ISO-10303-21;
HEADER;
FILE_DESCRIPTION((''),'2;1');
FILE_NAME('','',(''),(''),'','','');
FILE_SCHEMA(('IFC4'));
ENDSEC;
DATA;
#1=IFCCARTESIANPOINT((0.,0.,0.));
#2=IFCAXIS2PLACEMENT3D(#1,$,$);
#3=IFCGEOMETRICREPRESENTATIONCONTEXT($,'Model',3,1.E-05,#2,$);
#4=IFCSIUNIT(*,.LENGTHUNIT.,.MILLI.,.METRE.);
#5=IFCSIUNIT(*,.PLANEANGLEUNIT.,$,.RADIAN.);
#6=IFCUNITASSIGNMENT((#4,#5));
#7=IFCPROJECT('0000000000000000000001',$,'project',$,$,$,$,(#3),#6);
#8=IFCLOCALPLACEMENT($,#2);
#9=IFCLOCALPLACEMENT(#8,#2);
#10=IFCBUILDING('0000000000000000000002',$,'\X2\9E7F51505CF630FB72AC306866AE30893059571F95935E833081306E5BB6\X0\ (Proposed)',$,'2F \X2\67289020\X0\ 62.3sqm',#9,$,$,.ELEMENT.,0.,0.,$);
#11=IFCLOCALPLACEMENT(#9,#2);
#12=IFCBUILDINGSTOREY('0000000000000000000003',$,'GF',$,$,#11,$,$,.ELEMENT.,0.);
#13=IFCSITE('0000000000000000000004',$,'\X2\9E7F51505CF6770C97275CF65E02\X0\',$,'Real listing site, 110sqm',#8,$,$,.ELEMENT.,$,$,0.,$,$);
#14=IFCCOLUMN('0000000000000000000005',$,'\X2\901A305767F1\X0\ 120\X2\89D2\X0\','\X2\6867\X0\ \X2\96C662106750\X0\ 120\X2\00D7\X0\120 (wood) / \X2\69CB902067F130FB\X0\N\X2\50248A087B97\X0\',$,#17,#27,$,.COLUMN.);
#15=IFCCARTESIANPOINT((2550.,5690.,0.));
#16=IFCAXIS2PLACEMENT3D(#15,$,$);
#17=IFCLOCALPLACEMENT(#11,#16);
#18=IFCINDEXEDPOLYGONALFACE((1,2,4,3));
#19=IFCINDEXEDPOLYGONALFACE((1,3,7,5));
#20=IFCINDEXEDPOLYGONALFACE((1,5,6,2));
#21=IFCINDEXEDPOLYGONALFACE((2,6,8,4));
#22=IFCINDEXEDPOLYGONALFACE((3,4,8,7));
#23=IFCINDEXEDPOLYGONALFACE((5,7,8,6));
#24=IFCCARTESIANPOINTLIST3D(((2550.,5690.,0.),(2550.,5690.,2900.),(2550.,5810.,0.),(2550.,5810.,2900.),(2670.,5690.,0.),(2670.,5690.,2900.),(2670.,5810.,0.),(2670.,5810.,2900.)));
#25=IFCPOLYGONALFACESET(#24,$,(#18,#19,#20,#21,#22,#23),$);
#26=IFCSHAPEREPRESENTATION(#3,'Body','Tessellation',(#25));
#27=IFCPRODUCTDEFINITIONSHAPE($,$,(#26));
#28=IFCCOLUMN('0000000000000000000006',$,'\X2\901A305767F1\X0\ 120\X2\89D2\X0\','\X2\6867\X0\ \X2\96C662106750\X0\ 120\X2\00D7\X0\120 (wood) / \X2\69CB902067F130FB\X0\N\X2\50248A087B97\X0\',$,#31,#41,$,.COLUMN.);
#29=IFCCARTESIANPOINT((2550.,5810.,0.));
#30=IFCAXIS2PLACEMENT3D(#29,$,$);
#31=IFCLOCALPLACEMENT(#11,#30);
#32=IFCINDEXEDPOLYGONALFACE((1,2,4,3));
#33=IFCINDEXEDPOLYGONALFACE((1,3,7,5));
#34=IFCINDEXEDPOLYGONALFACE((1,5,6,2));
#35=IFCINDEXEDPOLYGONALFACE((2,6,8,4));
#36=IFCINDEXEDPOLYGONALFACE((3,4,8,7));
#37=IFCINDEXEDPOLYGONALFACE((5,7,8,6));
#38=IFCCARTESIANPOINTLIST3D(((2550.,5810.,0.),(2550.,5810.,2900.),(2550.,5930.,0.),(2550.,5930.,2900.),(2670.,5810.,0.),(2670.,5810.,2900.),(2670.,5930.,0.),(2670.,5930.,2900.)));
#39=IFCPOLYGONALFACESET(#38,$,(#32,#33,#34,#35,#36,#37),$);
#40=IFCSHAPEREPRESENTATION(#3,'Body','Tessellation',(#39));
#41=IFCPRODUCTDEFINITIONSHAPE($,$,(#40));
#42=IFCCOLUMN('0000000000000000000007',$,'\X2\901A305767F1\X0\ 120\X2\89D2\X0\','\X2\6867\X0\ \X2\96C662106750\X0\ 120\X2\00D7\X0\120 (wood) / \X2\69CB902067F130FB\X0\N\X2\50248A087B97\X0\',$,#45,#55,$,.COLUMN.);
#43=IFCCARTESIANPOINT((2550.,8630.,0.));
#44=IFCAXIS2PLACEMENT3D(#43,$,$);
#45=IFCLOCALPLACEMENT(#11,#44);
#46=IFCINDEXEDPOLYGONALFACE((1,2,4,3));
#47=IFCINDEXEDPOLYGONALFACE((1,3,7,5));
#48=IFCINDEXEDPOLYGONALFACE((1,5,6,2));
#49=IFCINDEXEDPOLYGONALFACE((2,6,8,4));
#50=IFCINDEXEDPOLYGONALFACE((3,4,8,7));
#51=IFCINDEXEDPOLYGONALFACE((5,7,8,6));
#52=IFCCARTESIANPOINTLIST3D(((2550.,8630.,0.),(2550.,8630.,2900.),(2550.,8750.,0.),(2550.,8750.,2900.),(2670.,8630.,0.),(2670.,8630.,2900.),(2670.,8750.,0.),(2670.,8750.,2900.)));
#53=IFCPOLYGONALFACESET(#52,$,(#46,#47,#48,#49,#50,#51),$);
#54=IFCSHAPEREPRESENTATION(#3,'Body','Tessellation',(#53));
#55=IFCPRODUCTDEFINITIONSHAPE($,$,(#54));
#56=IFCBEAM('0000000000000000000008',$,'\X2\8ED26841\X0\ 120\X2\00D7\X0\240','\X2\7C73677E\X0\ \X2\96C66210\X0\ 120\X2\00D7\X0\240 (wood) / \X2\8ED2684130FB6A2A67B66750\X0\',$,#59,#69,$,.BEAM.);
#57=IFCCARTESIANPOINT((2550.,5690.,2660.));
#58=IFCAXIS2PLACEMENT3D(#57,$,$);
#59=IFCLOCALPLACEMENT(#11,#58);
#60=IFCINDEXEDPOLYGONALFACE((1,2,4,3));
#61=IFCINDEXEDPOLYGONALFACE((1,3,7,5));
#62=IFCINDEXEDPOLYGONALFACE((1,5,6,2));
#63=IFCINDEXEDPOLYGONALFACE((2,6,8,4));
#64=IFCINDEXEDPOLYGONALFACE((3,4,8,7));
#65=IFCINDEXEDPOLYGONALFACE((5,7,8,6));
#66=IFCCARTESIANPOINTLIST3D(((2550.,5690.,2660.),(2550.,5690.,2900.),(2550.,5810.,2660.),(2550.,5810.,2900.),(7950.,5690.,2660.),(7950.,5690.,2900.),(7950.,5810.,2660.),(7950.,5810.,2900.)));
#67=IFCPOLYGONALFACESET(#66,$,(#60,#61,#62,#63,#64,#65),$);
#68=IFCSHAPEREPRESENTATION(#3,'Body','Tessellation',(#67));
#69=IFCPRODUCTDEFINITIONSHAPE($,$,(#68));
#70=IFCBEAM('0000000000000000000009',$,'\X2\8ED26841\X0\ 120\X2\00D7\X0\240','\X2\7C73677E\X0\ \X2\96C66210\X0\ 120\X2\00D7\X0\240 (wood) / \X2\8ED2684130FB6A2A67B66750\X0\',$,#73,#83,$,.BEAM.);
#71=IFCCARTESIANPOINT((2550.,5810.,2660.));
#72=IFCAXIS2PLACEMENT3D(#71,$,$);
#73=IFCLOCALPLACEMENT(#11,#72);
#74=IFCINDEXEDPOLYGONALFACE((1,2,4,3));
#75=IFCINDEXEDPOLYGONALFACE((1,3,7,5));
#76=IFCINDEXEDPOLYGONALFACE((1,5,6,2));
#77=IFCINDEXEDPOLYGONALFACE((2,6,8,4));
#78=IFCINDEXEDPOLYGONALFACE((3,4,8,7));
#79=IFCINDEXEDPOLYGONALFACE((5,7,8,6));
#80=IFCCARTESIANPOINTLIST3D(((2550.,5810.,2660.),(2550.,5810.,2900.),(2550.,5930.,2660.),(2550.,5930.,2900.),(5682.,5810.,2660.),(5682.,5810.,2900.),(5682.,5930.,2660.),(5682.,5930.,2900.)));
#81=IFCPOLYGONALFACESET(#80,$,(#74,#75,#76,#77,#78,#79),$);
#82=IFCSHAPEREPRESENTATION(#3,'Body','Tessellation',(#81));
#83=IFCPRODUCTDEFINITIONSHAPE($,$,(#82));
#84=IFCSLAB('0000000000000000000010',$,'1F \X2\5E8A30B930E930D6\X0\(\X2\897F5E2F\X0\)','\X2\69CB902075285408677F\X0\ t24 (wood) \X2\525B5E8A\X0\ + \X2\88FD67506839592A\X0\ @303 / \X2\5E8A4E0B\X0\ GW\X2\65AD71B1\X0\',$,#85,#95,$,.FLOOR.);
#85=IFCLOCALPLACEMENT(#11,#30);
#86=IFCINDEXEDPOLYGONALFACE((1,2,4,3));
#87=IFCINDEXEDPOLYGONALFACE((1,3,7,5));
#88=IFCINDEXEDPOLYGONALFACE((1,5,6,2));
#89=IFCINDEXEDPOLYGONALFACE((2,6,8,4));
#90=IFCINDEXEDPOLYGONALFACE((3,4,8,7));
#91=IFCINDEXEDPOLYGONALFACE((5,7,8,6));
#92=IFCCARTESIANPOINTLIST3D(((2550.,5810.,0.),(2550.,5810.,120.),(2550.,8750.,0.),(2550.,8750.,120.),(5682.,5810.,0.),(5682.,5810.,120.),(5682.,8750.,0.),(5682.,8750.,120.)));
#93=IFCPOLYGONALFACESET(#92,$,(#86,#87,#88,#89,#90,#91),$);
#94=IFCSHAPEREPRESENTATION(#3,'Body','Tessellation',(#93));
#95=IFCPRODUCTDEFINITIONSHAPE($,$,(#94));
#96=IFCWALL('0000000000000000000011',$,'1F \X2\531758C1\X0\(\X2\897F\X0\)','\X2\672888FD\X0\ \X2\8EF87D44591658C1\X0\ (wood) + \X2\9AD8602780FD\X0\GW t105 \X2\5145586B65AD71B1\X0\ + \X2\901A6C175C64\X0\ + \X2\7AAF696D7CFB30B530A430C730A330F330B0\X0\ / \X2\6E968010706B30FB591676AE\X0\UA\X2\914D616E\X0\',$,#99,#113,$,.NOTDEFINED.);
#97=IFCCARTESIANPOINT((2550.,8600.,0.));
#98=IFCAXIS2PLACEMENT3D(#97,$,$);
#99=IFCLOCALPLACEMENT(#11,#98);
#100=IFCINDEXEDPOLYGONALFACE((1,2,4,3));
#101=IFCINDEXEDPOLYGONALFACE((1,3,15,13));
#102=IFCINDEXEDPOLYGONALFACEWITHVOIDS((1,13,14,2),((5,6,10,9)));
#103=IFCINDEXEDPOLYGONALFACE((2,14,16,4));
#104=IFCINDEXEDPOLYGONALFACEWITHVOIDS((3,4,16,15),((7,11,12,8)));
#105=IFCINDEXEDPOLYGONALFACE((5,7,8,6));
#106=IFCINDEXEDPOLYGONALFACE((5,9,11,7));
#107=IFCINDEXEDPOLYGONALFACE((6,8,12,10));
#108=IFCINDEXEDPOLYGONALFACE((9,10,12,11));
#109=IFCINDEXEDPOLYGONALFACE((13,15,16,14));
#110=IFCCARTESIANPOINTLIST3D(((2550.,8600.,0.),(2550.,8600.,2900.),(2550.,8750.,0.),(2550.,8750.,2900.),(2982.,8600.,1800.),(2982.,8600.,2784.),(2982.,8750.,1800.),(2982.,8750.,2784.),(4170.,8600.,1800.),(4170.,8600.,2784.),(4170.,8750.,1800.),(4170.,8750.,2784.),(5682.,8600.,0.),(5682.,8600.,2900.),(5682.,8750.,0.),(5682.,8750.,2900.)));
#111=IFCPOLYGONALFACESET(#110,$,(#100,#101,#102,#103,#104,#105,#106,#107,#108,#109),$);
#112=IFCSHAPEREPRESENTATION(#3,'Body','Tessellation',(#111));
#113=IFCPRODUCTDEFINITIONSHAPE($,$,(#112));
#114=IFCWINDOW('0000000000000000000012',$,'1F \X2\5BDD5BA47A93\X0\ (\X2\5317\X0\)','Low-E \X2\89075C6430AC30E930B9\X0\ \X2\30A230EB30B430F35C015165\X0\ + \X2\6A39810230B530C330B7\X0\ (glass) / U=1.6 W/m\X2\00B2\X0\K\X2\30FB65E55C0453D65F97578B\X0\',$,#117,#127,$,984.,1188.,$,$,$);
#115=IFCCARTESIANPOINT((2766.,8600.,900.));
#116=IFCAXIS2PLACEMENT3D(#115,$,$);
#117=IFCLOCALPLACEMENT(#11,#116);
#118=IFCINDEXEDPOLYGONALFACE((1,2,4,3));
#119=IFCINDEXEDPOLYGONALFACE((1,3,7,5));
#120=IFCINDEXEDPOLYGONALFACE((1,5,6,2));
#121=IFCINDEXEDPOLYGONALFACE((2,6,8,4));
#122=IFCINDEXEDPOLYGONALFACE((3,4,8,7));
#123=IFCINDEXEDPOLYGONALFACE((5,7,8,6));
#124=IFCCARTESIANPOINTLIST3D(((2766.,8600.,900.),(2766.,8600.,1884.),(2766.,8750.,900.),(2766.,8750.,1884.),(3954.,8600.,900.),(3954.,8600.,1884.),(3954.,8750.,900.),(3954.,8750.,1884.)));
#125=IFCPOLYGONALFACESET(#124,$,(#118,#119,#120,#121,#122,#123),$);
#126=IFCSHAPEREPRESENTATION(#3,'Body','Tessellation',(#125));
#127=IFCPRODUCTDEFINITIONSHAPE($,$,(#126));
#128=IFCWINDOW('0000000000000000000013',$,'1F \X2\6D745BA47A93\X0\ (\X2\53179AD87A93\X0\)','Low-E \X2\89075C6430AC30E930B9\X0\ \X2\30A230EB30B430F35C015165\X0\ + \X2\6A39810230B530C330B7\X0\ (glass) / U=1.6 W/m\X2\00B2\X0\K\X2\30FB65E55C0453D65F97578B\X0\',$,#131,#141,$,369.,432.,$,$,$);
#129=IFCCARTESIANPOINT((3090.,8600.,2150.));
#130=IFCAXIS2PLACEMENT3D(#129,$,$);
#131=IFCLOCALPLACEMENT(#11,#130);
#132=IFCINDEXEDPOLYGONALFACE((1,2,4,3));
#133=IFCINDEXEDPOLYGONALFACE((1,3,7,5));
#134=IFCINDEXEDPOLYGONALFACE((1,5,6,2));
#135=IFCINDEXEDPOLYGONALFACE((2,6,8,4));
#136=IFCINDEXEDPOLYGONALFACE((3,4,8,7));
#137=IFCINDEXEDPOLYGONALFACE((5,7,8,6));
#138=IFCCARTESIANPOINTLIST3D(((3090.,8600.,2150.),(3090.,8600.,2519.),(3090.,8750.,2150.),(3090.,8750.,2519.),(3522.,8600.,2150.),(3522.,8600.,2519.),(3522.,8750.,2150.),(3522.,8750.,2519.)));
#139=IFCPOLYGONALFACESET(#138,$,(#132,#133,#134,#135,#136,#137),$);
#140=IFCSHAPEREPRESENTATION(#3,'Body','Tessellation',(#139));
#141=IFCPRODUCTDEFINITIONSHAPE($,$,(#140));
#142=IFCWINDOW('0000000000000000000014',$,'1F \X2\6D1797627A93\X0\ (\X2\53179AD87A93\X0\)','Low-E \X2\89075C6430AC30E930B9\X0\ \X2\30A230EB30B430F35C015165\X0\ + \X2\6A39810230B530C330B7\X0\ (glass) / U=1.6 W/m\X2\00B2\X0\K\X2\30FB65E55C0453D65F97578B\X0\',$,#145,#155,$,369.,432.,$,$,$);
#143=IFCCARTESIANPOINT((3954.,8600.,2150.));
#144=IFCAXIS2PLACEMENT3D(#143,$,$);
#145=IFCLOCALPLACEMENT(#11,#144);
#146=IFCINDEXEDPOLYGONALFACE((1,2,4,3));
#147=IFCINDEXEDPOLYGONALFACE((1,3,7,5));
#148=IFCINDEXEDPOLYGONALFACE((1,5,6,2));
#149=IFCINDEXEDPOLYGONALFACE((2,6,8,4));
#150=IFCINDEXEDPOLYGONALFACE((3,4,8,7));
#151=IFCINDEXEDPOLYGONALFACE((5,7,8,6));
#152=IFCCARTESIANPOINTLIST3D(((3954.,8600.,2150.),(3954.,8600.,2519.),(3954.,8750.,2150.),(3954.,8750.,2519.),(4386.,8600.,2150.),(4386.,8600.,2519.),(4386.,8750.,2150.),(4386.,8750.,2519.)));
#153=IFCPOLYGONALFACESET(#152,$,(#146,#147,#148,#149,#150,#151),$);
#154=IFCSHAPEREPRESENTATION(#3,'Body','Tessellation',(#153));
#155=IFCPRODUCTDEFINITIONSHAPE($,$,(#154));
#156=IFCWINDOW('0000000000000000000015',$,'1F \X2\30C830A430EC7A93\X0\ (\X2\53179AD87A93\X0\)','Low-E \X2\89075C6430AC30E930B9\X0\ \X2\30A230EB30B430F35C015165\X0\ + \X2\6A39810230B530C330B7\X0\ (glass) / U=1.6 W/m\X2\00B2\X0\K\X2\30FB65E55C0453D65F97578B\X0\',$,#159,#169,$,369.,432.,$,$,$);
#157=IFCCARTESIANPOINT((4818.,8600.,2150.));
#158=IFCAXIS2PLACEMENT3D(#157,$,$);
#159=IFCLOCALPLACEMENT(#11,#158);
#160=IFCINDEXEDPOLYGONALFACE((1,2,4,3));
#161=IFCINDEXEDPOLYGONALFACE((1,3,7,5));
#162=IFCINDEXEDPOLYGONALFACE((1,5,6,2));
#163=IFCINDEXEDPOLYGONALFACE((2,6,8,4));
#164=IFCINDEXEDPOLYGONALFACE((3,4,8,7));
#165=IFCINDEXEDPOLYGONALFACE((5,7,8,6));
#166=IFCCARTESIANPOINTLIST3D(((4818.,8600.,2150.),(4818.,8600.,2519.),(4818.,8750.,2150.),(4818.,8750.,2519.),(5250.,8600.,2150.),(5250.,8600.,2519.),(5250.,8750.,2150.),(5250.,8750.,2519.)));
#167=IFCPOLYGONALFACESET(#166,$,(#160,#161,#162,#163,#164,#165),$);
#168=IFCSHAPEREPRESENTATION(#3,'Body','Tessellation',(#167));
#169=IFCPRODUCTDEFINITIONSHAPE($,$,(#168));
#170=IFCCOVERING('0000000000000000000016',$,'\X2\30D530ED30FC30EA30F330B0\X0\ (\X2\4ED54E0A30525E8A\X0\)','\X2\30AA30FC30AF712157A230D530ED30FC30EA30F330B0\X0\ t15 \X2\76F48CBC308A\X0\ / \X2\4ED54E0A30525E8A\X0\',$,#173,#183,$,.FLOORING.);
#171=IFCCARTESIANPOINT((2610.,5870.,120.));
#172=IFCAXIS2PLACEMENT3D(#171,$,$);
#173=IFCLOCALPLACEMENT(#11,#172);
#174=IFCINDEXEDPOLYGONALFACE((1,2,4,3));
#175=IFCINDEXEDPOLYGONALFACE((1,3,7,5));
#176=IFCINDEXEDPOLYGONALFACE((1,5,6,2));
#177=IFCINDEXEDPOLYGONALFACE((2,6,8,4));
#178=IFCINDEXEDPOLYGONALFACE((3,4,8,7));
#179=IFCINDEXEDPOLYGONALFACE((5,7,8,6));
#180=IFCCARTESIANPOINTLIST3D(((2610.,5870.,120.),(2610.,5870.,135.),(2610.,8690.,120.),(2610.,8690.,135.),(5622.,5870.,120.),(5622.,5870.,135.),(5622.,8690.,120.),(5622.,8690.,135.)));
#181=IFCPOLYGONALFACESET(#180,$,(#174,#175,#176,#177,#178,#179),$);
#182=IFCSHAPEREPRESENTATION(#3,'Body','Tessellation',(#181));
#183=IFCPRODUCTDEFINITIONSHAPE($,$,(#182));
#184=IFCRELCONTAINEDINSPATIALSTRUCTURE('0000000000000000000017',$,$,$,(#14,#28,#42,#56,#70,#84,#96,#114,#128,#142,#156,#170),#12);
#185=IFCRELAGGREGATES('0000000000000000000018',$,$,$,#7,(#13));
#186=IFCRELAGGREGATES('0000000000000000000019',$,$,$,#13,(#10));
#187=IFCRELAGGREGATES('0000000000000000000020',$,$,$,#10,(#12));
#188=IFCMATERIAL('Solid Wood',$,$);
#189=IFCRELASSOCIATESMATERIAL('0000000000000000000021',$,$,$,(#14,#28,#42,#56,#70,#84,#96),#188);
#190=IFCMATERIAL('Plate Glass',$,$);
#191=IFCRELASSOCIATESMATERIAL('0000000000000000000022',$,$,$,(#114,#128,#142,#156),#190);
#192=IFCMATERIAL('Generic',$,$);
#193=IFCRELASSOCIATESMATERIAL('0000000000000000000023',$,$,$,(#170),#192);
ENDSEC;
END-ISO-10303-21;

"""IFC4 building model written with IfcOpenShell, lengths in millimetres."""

from ifc_helpers import new_model, si_unit, frame, frame_2d, origin, place, context, project, spatial, rectangle, extrude, material, element, fill, save


model = new_model("IFC4")

# Units and contexts
model_context = context("Model", 3, precision=1e-05, world=origin())
ifc_project = project(units=[si_unit("LENGTHUNIT", "METRE", prefix="MILLI"), si_unit("PLANEANGLEUNIT", "RADIAN")], contexts=[model_context])

# Site, building, storey
site_placement = place(None, origin())
site = spatial("IfcSite", under=ifc_project, at=site_placement, Name="鹿児島県霧島市", ObjectType="Real listing site, 110sqm", CompositionType="ELEMENT", RefElevation=0.0)
building_placement = place(site_placement, origin())
building = spatial("IfcBuilding", under=site, at=building_placement, Name="鹿児島・犬と暮らす土間広めの家 (Proposed)", ObjectType="2F 木造 62.3sqm", CompositionType="ELEMENT", ElevationOfRefHeight=0.0, ElevationOfTerrain=0.0)
storey_placement = place(building_placement, origin())
storey = spatial("IfcBuildingStorey", under=building, at=storey_placement, Name="GF", CompositionType="ELEMENT", Elevation=0.0)

# Columns
ifc_material_1 = material(Name="Solid Wood")
column_1_placement = place(storey_placement, frame((2550.0, 5690.0, 0.0)))
element("IfcColumn", 1, at=column_1_placement, inside=storey, material=ifc_material_1, Name="通し柱 120角", Description="桧 集成材 120×120 (wood) / 構造柱・N値計算", PredefinedType="COLUMN", context=model_context, shape_type="SweptSolid", body=[
    extrude(rectangle(XDim=120.0, YDim=120.0, at=frame_2d((60.0, 60.0))), frame((2550.0, 5690.0, 0.0)), (0.0, 0.0, 1.0), 2900.0),
])
column_2_placement = place(storey_placement, frame((2550.0, 5810.0, 0.0)))
element("IfcColumn", 2, at=column_2_placement, inside=storey, material=ifc_material_1, Name="通し柱 120角", Description="桧 集成材 120×120 (wood) / 構造柱・N値計算", PredefinedType="COLUMN", context=model_context, shape_type="SweptSolid", body=[
    extrude(rectangle(XDim=120.0, YDim=120.0, at=frame_2d((60.0, 60.0))), frame((2550.0, 5810.0, 0.0)), (0.0, 0.0, 1.0), 2900.0),
])
column_3_placement = place(storey_placement, frame((2550.0, 8630.0, 0.0)))
element("IfcColumn", 3, at=column_3_placement, inside=storey, material=ifc_material_1, Name="通し柱 120角", Description="桧 集成材 120×120 (wood) / 構造柱・N値計算", PredefinedType="COLUMN", context=model_context, shape_type="SweptSolid", body=[
    extrude(rectangle(XDim=120.0, YDim=120.0, at=frame_2d((60.0, 60.0))), frame((2550.0, 8630.0, 0.0)), (0.0, 0.0, 1.0), 2900.0),
])

# Beams
beam_1_placement = place(storey_placement, frame((2550.0, 5690.0, 2660.0)))
element("IfcBeam", 4, at=beam_1_placement, inside=storey, material=ifc_material_1, Name="軒桁 120×240", Description="米松 集成 120×240 (wood) / 軒桁・横架材", PredefinedType="BEAM", context=model_context, shape_type="SweptSolid", body=[
    extrude(rectangle(XDim=5400.0, YDim=120.0, at=frame_2d((2700.0, 60.0))), frame((2550.0, 5690.0, 2660.0)), (0.0, 0.0, 1.0), 240.0),
])
beam_2_placement = place(storey_placement, frame((2550.0, 5810.0, 2660.0)))
element("IfcBeam", 5, at=beam_2_placement, inside=storey, material=ifc_material_1, Name="軒桁 120×240", Description="米松 集成 120×240 (wood) / 軒桁・横架材", PredefinedType="BEAM", context=model_context, shape_type="SweptSolid", body=[
    extrude(rectangle(XDim=3132.0, YDim=120.0, at=frame_2d((1566.0, 60.0))), frame((2550.0, 5810.0, 2660.0)), (0.0, 0.0, 1.0), 240.0),
])

# Slab
slab_placement = place(storey_placement, frame((2550.0, 5810.0, 0.0)))
element("IfcSlab", 6, at=slab_placement, inside=storey, material=ifc_material_1, Name="1F 床スラブ(西帯)", Description="構造用合板 t24 (wood) 剛床 + 製材根太 @303 / 床下 GW断熱", PredefinedType="FLOOR", context=model_context, shape_type="SweptSolid", body=[
    extrude(rectangle(XDim=3132.0, YDim=2940.0, at=frame_2d((1566.0, 1470.0))), frame((2550.0, 5810.0, 0.0)), (0.0, 0.0, 1.0), 120.0),
])

# Wall, openings, windows
wall_1_placement = place(storey_placement, frame((2550.0, 8600.0, 0.0)))
wall_1 = element("IfcWall", 7, at=wall_1_placement, inside=storey, material=ifc_material_1, Name="1F 北壁(西)", Description="木製 軸組外壁 (wood) + 高性能GW t105 充填断熱 + 通気層 + 窯業系サイディング / 準耐火・外皮UA配慮", PredefinedType="NOTDEFINED", context=model_context, shape_type="SweptSolid", body=[
    extrude(rectangle(XDim=3132.0, YDim=150.0, at=frame_2d((1566.0, 75.0))), frame((2550.0, 8600.0, 0.0)), (0.0, 0.0, 1.0), 2900.0),
])
opening_1_placement = place(storey_placement, frame((2766.0, 8600.0, 900.0)))
opening_1 = element("IfcOpeningElement", 8, at=opening_1_placement, cuts=wall_1, PredefinedType="NOTDEFINED", context=model_context, shape_type="SweptSolid", body=[
    extrude(rectangle(XDim=1188.0, YDim=150.0, at=frame_2d((594.0, 75.0))), frame((2766.0, 8600.0, 900.0)), (0.0, 0.0, 1.0), 984.0),
])
opening_2_placement = place(storey_placement, frame((3090.0, 8600.0, 2150.0)))
opening_2 = element("IfcOpeningElement", 9, at=opening_2_placement, cuts=wall_1, PredefinedType="NOTDEFINED", context=model_context, shape_type="SweptSolid", body=[
    extrude(rectangle(XDim=432.0, YDim=150.0, at=frame_2d((216.0, 75.0))), frame((3090.0, 8600.0, 2150.0)), (0.0, 0.0, 1.0), 369.0),
])
opening_3_placement = place(storey_placement, frame((3954.0, 8600.0, 2150.0)))
opening_3 = element("IfcOpeningElement", 10, at=opening_3_placement, cuts=wall_1, PredefinedType="NOTDEFINED", context=model_context, shape_type="SweptSolid", body=[
    extrude(rectangle(XDim=432.0, YDim=150.0, at=frame_2d((216.0, 75.0))), frame((3954.0, 8600.0, 2150.0)), (0.0, 0.0, 1.0), 369.0),
])
opening_4_placement = place(storey_placement, frame((4818.0, 8600.0, 2150.0)))
opening_4 = element("IfcOpeningElement", 11, at=opening_4_placement, cuts=wall_1, PredefinedType="NOTDEFINED", context=model_context, shape_type="SweptSolid", body=[
    extrude(rectangle(XDim=432.0, YDim=150.0, at=frame_2d((216.0, 75.0))), frame((4818.0, 8600.0, 2150.0)), (0.0, 0.0, 1.0), 369.0),
])
ifc_material_2 = material(Name="Plate Glass")
window_1_placement = place(storey_placement, frame((2766.0, 8600.0, 900.0)))
window_1 = element("IfcWindow", 12, at=window_1_placement, inside=storey, material=ifc_material_2, Name="1F 寝室窓 (北)", Description="Low-E 複層ガラス アルゴン封入 + 樹脂サッシ (glass) / U=1.6 W/m²K・日射取得型", OverallHeight=984.0, OverallWidth=1188.0, context=model_context, shape_type="SweptSolid", body=[
    extrude(rectangle(XDim=1188.0, YDim=150.0, at=frame_2d((594.0, 75.0))), frame((2766.0, 8600.0, 900.0)), (0.0, 0.0, 1.0), 984.0),
])
fill(opening_1, window_1)
window_2_placement = place(storey_placement, frame((3090.0, 8600.0, 2150.0)))
window_2 = element("IfcWindow", 13, at=window_2_placement, inside=storey, material=ifc_material_2, Name="1F 浴室窓 (北高窓)", Description="Low-E 複層ガラス アルゴン封入 + 樹脂サッシ (glass) / U=1.6 W/m²K・日射取得型", OverallHeight=369.0, OverallWidth=432.0, context=model_context, shape_type="SweptSolid", body=[
    extrude(rectangle(XDim=432.0, YDim=150.0, at=frame_2d((216.0, 75.0))), frame((3090.0, 8600.0, 2150.0)), (0.0, 0.0, 1.0), 369.0),
])
fill(opening_2, window_2)
window_3_placement = place(storey_placement, frame((3954.0, 8600.0, 2150.0)))
window_3 = element("IfcWindow", 14, at=window_3_placement, inside=storey, material=ifc_material_2, Name="1F 洗面窓 (北高窓)", Description="Low-E 複層ガラス アルゴン封入 + 樹脂サッシ (glass) / U=1.6 W/m²K・日射取得型", OverallHeight=369.0, OverallWidth=432.0, context=model_context, shape_type="SweptSolid", body=[
    extrude(rectangle(XDim=432.0, YDim=150.0, at=frame_2d((216.0, 75.0))), frame((3954.0, 8600.0, 2150.0)), (0.0, 0.0, 1.0), 369.0),
])
fill(opening_3, window_3)
window_4_placement = place(storey_placement, frame((4818.0, 8600.0, 2150.0)))
window_4 = element("IfcWindow", 15, at=window_4_placement, inside=storey, material=ifc_material_2, Name="1F トイレ窓 (北高窓)", Description="Low-E 複層ガラス アルゴン封入 + 樹脂サッシ (glass) / U=1.6 W/m²K・日射取得型", OverallHeight=369.0, OverallWidth=432.0, context=model_context, shape_type="SweptSolid", body=[
    extrude(rectangle(XDim=432.0, YDim=150.0, at=frame_2d((216.0, 75.0))), frame((4818.0, 8600.0, 2150.0)), (0.0, 0.0, 1.0), 369.0),
])
fill(opening_4, window_4)

# Covering
ifc_material_3 = material(Name="Generic")
covering_placement = place(storey_placement, frame((2610.0, 5870.0, 120.0)))
element("IfcCovering", 16, at=covering_placement, inside=storey, material=ifc_material_3, Name="フローリング (仕上げ床)", Description="オーク無垢フローリング t15 直貼り / 仕上げ床", PredefinedType="FLOORING", context=model_context, shape_type="SweptSolid", body=[
    extrude(rectangle(XDim=3012.0, YDim=2820.0, at=frame_2d((1506.0, 1410.0))), frame((2610.0, 5870.0, 120.0)), (0.0, 0.0, 1.0), 15.0),
])

save(model, "model.ifc")
